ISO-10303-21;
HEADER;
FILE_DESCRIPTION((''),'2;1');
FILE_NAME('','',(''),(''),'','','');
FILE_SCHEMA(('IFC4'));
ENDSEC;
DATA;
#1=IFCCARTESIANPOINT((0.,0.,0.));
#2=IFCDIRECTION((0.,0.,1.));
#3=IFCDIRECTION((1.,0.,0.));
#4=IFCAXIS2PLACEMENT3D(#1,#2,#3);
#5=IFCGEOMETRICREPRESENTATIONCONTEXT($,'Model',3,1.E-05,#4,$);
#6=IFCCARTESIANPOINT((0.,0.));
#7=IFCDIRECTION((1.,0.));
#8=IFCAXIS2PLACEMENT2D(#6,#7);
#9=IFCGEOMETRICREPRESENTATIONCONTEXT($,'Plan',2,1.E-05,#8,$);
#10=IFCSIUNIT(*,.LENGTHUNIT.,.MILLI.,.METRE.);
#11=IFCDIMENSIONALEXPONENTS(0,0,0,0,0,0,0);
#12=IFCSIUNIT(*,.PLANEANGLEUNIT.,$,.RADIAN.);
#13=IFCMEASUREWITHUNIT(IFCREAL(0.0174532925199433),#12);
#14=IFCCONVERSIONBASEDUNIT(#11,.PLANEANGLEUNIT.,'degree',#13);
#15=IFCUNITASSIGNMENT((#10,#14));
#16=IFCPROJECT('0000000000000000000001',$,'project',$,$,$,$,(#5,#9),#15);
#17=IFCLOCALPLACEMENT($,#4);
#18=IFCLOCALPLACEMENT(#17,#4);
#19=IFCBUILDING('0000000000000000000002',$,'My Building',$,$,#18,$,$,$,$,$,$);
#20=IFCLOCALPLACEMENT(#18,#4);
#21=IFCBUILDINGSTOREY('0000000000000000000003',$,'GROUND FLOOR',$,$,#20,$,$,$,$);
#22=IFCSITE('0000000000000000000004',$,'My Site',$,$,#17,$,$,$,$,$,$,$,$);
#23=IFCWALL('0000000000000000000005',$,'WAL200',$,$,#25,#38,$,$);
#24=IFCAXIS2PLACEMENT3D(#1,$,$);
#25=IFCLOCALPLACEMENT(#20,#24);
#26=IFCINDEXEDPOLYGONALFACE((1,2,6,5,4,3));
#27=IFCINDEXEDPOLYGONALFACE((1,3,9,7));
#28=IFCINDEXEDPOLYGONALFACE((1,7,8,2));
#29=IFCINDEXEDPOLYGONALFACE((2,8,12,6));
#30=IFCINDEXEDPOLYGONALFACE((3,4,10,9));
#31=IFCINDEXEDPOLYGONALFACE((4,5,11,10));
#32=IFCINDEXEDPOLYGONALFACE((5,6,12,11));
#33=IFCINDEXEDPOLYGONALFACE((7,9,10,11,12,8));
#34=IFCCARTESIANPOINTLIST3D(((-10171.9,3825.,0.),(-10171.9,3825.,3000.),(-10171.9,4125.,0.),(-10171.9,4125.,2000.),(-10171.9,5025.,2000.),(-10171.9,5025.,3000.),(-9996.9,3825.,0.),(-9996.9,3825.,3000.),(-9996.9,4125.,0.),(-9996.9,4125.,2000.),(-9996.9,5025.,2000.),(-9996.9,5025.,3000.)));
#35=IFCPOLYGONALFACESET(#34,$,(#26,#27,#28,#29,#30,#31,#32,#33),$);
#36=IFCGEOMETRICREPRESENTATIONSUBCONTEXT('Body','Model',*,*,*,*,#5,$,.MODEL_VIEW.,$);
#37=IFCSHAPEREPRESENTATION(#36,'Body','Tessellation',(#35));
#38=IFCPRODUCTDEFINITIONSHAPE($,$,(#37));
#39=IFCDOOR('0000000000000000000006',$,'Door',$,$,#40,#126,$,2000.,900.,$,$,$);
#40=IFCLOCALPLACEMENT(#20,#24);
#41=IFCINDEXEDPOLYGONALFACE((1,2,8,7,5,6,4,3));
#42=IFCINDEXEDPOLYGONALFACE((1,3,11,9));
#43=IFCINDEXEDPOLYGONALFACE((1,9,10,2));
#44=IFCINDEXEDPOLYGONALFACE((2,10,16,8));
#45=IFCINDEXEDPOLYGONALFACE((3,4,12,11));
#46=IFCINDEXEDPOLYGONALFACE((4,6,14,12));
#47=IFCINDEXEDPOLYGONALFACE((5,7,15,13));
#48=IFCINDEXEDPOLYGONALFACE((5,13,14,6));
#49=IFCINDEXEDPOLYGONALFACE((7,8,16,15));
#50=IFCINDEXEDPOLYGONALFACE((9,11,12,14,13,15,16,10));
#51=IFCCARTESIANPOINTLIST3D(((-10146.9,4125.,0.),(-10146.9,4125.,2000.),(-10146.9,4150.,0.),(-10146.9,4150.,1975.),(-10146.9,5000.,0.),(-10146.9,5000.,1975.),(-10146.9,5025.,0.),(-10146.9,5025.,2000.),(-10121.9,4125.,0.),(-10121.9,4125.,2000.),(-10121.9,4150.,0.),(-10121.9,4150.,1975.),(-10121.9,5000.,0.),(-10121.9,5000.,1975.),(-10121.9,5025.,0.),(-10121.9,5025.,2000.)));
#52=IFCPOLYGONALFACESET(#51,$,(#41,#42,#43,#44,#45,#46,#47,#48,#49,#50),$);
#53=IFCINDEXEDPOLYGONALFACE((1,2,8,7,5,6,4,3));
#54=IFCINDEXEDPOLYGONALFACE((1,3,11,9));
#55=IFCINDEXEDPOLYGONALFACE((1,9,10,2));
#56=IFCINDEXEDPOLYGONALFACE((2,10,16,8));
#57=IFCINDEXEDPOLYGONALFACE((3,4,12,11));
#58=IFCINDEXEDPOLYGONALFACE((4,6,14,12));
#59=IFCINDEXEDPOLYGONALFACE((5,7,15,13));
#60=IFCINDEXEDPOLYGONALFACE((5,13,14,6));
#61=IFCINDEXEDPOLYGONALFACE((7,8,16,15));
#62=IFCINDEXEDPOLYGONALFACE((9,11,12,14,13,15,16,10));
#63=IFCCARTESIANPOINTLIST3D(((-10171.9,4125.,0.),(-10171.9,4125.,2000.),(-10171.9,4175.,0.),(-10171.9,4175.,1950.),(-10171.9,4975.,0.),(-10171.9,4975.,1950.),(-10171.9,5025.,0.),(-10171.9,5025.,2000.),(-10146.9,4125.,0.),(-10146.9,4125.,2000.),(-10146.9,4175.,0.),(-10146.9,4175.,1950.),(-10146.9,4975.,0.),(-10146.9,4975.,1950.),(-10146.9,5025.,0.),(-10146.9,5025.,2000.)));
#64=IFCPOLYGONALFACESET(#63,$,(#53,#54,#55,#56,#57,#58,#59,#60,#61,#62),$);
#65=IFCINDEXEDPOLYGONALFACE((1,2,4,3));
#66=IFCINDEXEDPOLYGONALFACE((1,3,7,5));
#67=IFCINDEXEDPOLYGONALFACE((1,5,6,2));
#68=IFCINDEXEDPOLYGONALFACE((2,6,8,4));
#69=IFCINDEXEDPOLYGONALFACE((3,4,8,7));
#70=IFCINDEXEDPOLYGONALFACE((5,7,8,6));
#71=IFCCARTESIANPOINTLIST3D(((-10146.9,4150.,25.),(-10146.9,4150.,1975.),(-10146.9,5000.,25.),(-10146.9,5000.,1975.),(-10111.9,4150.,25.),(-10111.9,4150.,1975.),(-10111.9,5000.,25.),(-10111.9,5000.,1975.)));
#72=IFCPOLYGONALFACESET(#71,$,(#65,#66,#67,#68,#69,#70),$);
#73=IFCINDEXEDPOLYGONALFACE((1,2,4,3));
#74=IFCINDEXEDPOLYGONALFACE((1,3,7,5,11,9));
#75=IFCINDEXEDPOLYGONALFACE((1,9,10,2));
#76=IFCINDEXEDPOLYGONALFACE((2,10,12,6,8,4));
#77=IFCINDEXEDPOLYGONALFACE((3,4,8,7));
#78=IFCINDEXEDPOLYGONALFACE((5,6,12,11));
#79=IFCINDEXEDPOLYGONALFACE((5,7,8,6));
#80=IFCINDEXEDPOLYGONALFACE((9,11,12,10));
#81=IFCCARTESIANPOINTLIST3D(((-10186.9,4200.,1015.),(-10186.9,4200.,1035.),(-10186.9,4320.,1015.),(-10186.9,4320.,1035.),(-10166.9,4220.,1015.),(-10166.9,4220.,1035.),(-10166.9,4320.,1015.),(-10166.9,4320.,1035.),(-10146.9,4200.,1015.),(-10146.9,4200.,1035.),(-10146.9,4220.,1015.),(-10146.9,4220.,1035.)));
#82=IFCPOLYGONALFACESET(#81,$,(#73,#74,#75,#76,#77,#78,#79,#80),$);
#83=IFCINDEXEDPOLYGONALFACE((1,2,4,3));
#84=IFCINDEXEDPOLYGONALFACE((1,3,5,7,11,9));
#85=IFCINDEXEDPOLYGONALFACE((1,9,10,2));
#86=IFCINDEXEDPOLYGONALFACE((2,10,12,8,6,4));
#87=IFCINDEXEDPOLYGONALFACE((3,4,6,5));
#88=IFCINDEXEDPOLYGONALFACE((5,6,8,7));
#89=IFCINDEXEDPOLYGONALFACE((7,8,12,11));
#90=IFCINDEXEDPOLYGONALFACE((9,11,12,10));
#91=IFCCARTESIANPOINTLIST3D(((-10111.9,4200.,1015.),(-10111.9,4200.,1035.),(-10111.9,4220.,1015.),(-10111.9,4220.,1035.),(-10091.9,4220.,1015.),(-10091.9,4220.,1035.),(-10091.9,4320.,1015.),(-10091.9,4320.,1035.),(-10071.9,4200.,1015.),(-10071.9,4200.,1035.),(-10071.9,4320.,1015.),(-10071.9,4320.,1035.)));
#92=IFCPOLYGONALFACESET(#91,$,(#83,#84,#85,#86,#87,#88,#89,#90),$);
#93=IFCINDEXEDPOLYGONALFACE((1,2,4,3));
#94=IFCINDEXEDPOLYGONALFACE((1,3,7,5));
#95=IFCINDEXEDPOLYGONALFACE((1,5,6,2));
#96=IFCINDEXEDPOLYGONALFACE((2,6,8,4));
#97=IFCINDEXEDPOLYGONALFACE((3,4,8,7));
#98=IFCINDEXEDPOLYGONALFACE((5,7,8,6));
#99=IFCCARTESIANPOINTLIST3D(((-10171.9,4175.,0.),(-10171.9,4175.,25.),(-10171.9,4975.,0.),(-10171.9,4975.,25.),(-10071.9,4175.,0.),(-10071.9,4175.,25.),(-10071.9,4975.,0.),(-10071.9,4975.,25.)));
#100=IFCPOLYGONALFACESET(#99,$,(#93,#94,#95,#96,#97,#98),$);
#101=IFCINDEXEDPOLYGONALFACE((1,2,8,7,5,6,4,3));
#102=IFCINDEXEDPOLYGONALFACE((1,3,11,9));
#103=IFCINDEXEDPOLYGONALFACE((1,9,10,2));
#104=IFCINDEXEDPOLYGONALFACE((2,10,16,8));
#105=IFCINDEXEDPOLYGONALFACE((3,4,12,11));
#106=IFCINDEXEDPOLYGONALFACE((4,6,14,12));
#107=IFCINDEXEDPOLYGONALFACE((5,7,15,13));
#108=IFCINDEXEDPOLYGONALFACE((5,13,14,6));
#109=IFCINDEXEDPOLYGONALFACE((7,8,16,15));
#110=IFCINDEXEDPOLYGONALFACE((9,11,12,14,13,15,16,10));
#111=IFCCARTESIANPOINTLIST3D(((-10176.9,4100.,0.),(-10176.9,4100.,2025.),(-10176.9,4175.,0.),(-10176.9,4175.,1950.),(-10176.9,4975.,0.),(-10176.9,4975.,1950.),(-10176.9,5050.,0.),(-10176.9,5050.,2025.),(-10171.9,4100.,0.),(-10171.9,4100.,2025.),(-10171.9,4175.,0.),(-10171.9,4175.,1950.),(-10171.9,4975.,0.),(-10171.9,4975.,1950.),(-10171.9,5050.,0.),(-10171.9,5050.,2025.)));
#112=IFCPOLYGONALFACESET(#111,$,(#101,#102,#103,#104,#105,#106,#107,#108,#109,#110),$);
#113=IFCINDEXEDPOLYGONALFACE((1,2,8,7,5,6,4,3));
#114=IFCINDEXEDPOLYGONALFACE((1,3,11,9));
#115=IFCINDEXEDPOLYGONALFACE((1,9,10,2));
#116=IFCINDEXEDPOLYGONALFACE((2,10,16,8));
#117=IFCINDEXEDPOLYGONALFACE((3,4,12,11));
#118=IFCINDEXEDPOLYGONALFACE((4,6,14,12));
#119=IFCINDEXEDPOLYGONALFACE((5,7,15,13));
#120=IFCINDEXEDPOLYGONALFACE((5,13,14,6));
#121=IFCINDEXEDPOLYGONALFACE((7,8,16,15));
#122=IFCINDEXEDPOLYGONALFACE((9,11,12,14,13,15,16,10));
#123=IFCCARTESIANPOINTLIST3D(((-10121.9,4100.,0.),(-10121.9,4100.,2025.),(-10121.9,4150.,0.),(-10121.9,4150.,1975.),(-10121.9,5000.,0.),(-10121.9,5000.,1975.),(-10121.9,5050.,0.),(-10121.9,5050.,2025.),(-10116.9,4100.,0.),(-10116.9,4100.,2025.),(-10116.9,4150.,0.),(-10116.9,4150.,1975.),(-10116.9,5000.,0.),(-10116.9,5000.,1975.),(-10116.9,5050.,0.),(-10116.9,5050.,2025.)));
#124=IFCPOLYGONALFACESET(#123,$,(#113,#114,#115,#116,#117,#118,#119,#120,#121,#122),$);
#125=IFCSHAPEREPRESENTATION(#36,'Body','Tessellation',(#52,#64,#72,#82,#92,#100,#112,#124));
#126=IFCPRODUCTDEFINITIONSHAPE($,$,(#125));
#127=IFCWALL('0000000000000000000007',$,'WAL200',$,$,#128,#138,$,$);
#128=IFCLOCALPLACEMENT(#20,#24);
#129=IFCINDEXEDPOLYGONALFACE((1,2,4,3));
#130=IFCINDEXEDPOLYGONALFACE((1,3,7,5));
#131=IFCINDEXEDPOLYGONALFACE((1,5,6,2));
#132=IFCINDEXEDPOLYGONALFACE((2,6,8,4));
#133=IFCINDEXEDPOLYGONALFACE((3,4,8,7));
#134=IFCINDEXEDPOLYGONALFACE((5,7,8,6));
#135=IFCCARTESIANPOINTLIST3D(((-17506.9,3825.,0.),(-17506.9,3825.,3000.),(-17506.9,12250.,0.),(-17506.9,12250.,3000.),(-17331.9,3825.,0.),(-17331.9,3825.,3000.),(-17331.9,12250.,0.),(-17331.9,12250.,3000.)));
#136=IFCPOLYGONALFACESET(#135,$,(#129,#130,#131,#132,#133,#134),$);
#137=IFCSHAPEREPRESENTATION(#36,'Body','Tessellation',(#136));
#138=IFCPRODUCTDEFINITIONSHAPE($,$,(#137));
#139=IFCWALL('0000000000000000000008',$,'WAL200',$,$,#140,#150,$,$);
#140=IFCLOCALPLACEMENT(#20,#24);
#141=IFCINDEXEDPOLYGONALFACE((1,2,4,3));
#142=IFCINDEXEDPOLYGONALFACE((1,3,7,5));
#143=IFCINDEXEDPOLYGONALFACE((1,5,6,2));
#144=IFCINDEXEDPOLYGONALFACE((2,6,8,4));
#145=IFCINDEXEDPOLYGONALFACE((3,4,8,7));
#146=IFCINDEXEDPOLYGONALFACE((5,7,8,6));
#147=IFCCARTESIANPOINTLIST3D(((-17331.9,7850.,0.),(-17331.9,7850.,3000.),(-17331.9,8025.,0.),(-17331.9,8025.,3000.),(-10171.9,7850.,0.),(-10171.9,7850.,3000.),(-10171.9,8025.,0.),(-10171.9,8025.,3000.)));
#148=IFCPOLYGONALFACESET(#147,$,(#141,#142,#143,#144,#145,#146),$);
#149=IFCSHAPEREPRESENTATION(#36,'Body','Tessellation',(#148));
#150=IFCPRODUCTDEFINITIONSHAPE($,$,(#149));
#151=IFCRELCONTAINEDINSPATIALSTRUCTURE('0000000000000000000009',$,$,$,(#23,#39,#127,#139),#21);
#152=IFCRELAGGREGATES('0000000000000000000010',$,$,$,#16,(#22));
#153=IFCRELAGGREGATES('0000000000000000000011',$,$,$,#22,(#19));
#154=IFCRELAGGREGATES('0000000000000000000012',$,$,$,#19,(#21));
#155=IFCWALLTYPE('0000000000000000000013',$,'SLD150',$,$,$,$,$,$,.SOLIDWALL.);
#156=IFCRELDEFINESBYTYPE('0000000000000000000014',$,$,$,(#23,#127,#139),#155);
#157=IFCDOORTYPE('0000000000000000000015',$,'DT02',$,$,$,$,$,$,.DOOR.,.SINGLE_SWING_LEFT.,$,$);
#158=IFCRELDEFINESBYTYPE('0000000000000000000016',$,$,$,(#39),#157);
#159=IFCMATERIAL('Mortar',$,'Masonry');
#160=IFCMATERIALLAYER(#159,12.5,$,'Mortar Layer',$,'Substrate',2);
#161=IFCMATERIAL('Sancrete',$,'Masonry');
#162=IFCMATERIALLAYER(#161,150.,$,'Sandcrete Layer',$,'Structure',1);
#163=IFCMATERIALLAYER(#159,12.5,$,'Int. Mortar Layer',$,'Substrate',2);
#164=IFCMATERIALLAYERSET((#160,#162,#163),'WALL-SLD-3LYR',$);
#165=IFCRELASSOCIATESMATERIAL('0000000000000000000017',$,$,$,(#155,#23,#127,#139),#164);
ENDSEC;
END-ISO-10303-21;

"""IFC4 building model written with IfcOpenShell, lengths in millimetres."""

from ifc_helpers import new_model, entity, si_unit, converted_unit, frame, origin_with_axes, origin_2d_with_axis, place, context, subcontext, project, spatial, line, indexed_curve, outline, extrude, shape, source, transform, mapped, material, layer, layer_set, layer_usage, type_object, type_shapes, element, fill, save


model = new_model("IFC4")

# Units and contexts
model_context = context("Model", 3, precision=1e-05, world=origin_with_axes())
plan_context = context("Plan", 2, precision=1e-05, world=origin_2d_with_axis())
body_context_1 = subcontext(model_context, "Body", "Model", "MODEL_VIEW")
body_context_2 = subcontext(plan_context, "Body", "Plan", "PLAN_VIEW")
ifc_project = project(units=[si_unit("LENGTHUNIT", "METRE", prefix="MILLI"), converted_unit("PLANEANGLEUNIT", "degree", entity("IfcReal", 0.0174532925199433), si_unit("PLANEANGLEUNIT", "RADIAN"), dimensions=[0, 0, 0, 0, 0, 0, 0])], contexts=[model_context, plan_context])

# Site, building, storey
site_placement = place(None, origin_with_axes())
site = spatial("IfcSite", under=ifc_project, at=site_placement, Name="My Site")
building_placement = place(site_placement, origin_with_axes())
building = spatial("IfcBuilding", under=site, at=building_placement, Name="My Building")
storey_placement = place(building_placement, origin_with_axes())
storey = spatial("IfcBuildingStorey", under=building, at=storey_placement, Name="GROUND FLOOR")

# Wall, opening, door
ifc_material_1 = material(Name="Mortar", Category="Masonry")
ifc_layer_1 = layer(ifc_material_1, 12.5, Name="Mortar Layer", Category="Substrate", Priority=2)
ifc_material_2 = material(Name="Sancrete", Category="Masonry")
ifc_layer_2 = layer(ifc_material_2, 150.0, Name="Sandcrete Layer", Category="Structure", Priority=1)
ifc_layer_3 = layer(ifc_material_1, 12.5, Name="Int. Mortar Layer", Category="Substrate", Priority=2)
ifc_layer_set_1 = layer_set([ifc_layer_1, ifc_layer_2, ifc_layer_3], Name="WALL-SLD-3LYR")
wall_type = type_object("IfcWallType", Name="SLD150", PredefinedType="SOLIDWALL", material=ifc_layer_set_1)
shared_shape_1 = source(origin_with_axes(), body_context_1, "Body", "SweptSolid", [
    extrude(outline(indexed_curve([(0.0, 0.0), (900.0, 0.0), (900.0, 2000.0), (0.0, 2000.0)], segments=[line(1, 2), line(2, 3), line(3, 4), line(4, 1)])), frame((0.0, -100.0, 0.0), z_axis=(0.0, -1.0, 0.0), x_axis=(1.0, 0.0, 0.0)), (0.0, 0.0, -1.0), 300.0),
])
door_type = type_object("IfcDoorType", Name="DT02", OperationType="SINGLE_SWING_LEFT", PredefinedType="DOOR")
shared_shape_2 = source(origin_with_axes(), body_context_1, "Body", "SweptSolid", [
    extrude(outline(indexed_curve([(0.0, 0.0), (0.0, 2000.0), (900.0, 2000.0), (900.0, 0.0), (875.0, 0.0), (875.0, 1975.0), (25.0, 1975.0), (25.0, 0.0)], segments=[line(1, 2), line(2, 3), line(3, 4), line(4, 5), line(5, 6), line(6, 7), line(7, 8), line(8, 1)])), frame((0.0, 25.0, 0.0), z_axis=(0.0, -1.0, 0.0), x_axis=(1.0, 0.0, 0.0)), (0.0, 0.0, -1.0), 25.0),
    extrude(outline(indexed_curve([(0.0, 0.0), (0.0, 2000.0), (900.0, 2000.0), (900.0, 0.0), (850.0, 0.0), (850.0, 1950.0), (50.0, 1950.0), (50.0, 0.0)], segments=[line(1, 2), line(2, 3), line(3, 4), line(4, 5), line(5, 6), line(6, 7), line(7, 8), line(8, 1)])), frame((0.0, 0.0, 0.0), z_axis=(0.0, -1.0, 0.0), x_axis=(1.0, 0.0, 0.0)), (0.0, 0.0, -1.0), 25.0),
    extrude(outline(indexed_curve([(0.0, 0.0), (850.0, 0.0), (850.0, 35.0), (0.0, 35.0)], segments=[line(1, 2), line(2, 3), line(3, 4), line(4, 1)])), frame((25.0, 25.0, 25.0), z_axis=(0.0, 0.0, 1.0), x_axis=(1.0, 0.0, 0.0)), (0.0, 0.0, 1.0), 1950.0),
    extrude(outline(indexed_curve([(0.0, 0.0), (0.0, -40.0), (-120.0, -40.0), (-120.0, -20.0), (-20.0, -20.0), (-20.0, 0.0)], segments=[line(1, 2), line(2, 3), line(3, 4), line(4, 5), line(5, 6), line(6, 1)])), frame((825.0, 25.0, 1015.0), z_axis=(0.0, 0.0, 1.0), x_axis=(1.0, 0.0, 0.0)), (0.0, 0.0, 1.0), 20.0),
    extrude(outline(indexed_curve([(0.0, 0.0), (0.0, 40.0), (-120.0, 40.0), (-120.0, 20.0), (-20.0, 20.0), (-20.0, 0.0)], segments=[line(1, 2), line(2, 3), line(3, 4), line(4, 5), line(5, 6), line(6, 1)])), frame((825.0, 60.0, 1015.0), z_axis=(0.0, 0.0, 1.0), x_axis=(1.0, 0.0, 0.0)), (0.0, 0.0, 1.0), 20.0),
    extrude(outline(indexed_curve([(0.0, 0.0), (800.0, 0.0), (800.0, 100.0), (0.0, 100.0)], segments=[line(1, 2), line(2, 3), line(3, 4), line(4, 1)])), frame((50.0, 0.0, 0.0), z_axis=(0.0, 0.0, 1.0), x_axis=(1.0, 0.0, 0.0)), (0.0, 0.0, 1.0), 25.0),
    extrude(outline(indexed_curve([(0.0, 0.0), (0.0, 2025.0), (950.0, 2025.0), (950.0, 0.0), (875.0, 0.0), (875.0, 1950.0), (75.0, 1950.0), (75.0, 0.0)], segments=[line(1, 2), line(2, 3), line(3, 4), line(4, 5), line(5, 6), line(6, 7), line(7, 8), line(8, 1)])), frame((-25.0, -5.0, 0.0), z_axis=(0.0, -1.0, 0.0), x_axis=(1.0, 0.0, 0.0)), (0.0, 0.0, -1.0), 5.0),
    extrude(outline(indexed_curve([(0.0, 0.0), (0.0, 2025.0), (950.0, 2025.0), (950.0, 0.0), (900.0, 0.0), (900.0, 1975.0), (50.0, 1975.0), (50.0, 0.0)], segments=[line(1, 2), line(2, 3), line(3, 4), line(4, 5), line(5, 6), line(6, 7), line(7, 8), line(8, 1)])), frame((-25.0, 50.0, 0.0), z_axis=(0.0, -1.0, 0.0), x_axis=(1.0, 0.0, 0.0)), (0.0, 0.0, -1.0), 5.0),
])
shared_shape_3 = source(origin_with_axes(), body_context_2, "Body", "Curve2D", [
    entity("IfcIndexedPolyCurve", entity("IfcCartesianPointList2D", [[0.0, 0.0], [0.0, 50.0], [25.0, 50.0], [25.0, 25.0], [50.0, 25.0], [50.0, 0.0]]), [entity("IfcLineIndex", [1, 2]), entity("IfcLineIndex", [2, 3]), entity("IfcLineIndex", [3, 4]), entity("IfcLineIndex", [4, 5]), entity("IfcLineIndex", [5, 6]), entity("IfcLineIndex", [6, 1])]),
    entity("IfcIndexedPolyCurve", entity("IfcCartesianPointList2D", [[900.0, 0.0], [900.0, 50.0], [875.0, 50.0], [875.0, 25.0], [850.0, 25.0], [850.0, 0.0]]), [entity("IfcLineIndex", [1, 2]), entity("IfcLineIndex", [2, 3]), entity("IfcLineIndex", [3, 4]), entity("IfcLineIndex", [4, 5]), entity("IfcLineIndex", [5, 6]), entity("IfcLineIndex", [6, 1])]),
    entity("IfcTrimmedCurve", entity("IfcEllipse", entity("IfcAxis2Placement2D", entity("IfcCartesianPoint", [60.0, 50.0]), entity("IfcDirection", [1.0, 0.0])), 815.0, 850.0), [entity("IfcCartesianPoint", [875.0, 50.0])], [entity("IfcCartesianPoint", [60.0, 900.0])], True, "CARTESIAN"),
    entity("IfcIndexedPolyCurve", entity("IfcCartesianPointList2D", [[25.0, 50.0], [60.0, 50.0], [60.0, 900.0], [25.0, 900.0]]), [entity("IfcLineIndex", [1, 2]), entity("IfcLineIndex", [2, 3]), entity("IfcLineIndex", [3, 4]), entity("IfcLineIndex", [4, 1])]),
])
type_shapes(door_type, [shared_shape_2, shared_shape_3])
ifc_layer_usage_1 = layer_usage(ifc_layer_set_1, "AXIS2", "POSITIVE", 0.0)
wall_1_placement = place(storey_placement, frame((-10171.9, 5025.0, 0.0), z_axis=(0.0, 0.0, 1.0), x_axis=(-0.000001, -1.0, 0.0)))
wall_1 = element("IfcWall", 1, at=wall_1_placement, inside=storey, type_object=wall_type, material=ifc_layer_usage_1, Name="WAL200", context=body_context_1, shape_type="SweptSolid", body=[
    extrude(outline(indexed_curve([(0.0, 0.0), (0.0, 175.0), (1200.0, 175.0), (1200.0, 0.0), (0.0, 0.0)], self_intersect=False)), origin_with_axes(), (0.0, 0.0, 1.0), 3000.0),
])
opening_1_placement = place(wall_1_placement, frame((0.0, 0.0, 0.0), z_axis=(0.0, 0.0, 1.0), x_axis=(1.0, 0.0, 0.0)))
opening_1 = element("IfcOpeningElement", 2, at=opening_1_placement, cuts=wall_1, PredefinedType="OPENING", context=body_context_1, shape_type="MappedRepresentation", body=[
    mapped(shared_shape_1, transform((0.0, 0.0, 0.0), x_axis=(1.0, 0.0, 0.0), y_axis=(0.0, 1.0, 0.0), z_axis=(0.0, 0.0, 1.0), scale=1.0)),
])
door_1_placement = place(opening_1_placement, origin_with_axes())
door_1 = element("IfcDoor", 3, at=door_1_placement, inside=storey, type_object=door_type, Name="Door", OverallHeight=2000.0, OverallWidth=900.0, shapes=[
    shape(body_context_1, "Body", "MappedRepresentation", [mapped(shared_shape_2, transform((0.0, 0.0, 0.0), x_axis=(1.0, 0.0, 0.0), y_axis=(0.0, 1.0, 0.0), z_axis=(0.0, 0.0, 1.0), scale=1.0))]),
    shape(body_context_2, "Body", "MappedRepresentation", [mapped(shared_shape_3, transform((0.0, 0.0, 0.0), x_axis=(1.0, 0.0, 0.0), y_axis=(0.0, 1.0, 0.0), z_axis=(0.0, 0.0, 1.0), scale=1.0))]),
])
fill(opening_1, door_1)

# Walls
ifc_layer_usage_2 = layer_usage(ifc_layer_set_1, "AXIS2", "POSITIVE", 0.0)
wall_2_placement = place(storey_placement, frame((-17331.9, 3825.0, 0.0), z_axis=(0.0, 0.0, 1.0), x_axis=(0.0, 1.0, 0.0)))
element("IfcWall", 4, at=wall_2_placement, inside=storey, type_object=wall_type, material=ifc_layer_usage_2, Name="WAL200", context=body_context_1, shape_type="SweptSolid", body=[
    extrude(outline(indexed_curve([(0.0, 0.0), (0.0, 175.0), (8425.0, 175.0), (8425.0, 0.0), (0.0, 0.0)], self_intersect=False)), origin_with_axes(), (0.0, 0.0, 1.0), 3000.0),
])
ifc_layer_usage_3 = layer_usage(ifc_layer_set_1, "AXIS2", "POSITIVE", 0.0)
wall_3_placement = place(storey_placement, frame((-10171.9, 8025.0, 0.0), z_axis=(0.0, 0.0, 1.0), x_axis=(-1.0, 0.0, 0.0)))
element("IfcWall", 5, at=wall_3_placement, inside=storey, type_object=wall_type, material=ifc_layer_usage_3, Name="WAL200", context=body_context_1, shape_type="SweptSolid", body=[
    extrude(outline(indexed_curve([(0.0, 0.0), (0.0, 175.0), (7160.0, 175.0), (7160.0, 0.0), (0.0, 0.0)], self_intersect=False)), origin_with_axes(), (0.0, 0.0, 1.0), 3000.0),
])

save(model, "model.ifc")
